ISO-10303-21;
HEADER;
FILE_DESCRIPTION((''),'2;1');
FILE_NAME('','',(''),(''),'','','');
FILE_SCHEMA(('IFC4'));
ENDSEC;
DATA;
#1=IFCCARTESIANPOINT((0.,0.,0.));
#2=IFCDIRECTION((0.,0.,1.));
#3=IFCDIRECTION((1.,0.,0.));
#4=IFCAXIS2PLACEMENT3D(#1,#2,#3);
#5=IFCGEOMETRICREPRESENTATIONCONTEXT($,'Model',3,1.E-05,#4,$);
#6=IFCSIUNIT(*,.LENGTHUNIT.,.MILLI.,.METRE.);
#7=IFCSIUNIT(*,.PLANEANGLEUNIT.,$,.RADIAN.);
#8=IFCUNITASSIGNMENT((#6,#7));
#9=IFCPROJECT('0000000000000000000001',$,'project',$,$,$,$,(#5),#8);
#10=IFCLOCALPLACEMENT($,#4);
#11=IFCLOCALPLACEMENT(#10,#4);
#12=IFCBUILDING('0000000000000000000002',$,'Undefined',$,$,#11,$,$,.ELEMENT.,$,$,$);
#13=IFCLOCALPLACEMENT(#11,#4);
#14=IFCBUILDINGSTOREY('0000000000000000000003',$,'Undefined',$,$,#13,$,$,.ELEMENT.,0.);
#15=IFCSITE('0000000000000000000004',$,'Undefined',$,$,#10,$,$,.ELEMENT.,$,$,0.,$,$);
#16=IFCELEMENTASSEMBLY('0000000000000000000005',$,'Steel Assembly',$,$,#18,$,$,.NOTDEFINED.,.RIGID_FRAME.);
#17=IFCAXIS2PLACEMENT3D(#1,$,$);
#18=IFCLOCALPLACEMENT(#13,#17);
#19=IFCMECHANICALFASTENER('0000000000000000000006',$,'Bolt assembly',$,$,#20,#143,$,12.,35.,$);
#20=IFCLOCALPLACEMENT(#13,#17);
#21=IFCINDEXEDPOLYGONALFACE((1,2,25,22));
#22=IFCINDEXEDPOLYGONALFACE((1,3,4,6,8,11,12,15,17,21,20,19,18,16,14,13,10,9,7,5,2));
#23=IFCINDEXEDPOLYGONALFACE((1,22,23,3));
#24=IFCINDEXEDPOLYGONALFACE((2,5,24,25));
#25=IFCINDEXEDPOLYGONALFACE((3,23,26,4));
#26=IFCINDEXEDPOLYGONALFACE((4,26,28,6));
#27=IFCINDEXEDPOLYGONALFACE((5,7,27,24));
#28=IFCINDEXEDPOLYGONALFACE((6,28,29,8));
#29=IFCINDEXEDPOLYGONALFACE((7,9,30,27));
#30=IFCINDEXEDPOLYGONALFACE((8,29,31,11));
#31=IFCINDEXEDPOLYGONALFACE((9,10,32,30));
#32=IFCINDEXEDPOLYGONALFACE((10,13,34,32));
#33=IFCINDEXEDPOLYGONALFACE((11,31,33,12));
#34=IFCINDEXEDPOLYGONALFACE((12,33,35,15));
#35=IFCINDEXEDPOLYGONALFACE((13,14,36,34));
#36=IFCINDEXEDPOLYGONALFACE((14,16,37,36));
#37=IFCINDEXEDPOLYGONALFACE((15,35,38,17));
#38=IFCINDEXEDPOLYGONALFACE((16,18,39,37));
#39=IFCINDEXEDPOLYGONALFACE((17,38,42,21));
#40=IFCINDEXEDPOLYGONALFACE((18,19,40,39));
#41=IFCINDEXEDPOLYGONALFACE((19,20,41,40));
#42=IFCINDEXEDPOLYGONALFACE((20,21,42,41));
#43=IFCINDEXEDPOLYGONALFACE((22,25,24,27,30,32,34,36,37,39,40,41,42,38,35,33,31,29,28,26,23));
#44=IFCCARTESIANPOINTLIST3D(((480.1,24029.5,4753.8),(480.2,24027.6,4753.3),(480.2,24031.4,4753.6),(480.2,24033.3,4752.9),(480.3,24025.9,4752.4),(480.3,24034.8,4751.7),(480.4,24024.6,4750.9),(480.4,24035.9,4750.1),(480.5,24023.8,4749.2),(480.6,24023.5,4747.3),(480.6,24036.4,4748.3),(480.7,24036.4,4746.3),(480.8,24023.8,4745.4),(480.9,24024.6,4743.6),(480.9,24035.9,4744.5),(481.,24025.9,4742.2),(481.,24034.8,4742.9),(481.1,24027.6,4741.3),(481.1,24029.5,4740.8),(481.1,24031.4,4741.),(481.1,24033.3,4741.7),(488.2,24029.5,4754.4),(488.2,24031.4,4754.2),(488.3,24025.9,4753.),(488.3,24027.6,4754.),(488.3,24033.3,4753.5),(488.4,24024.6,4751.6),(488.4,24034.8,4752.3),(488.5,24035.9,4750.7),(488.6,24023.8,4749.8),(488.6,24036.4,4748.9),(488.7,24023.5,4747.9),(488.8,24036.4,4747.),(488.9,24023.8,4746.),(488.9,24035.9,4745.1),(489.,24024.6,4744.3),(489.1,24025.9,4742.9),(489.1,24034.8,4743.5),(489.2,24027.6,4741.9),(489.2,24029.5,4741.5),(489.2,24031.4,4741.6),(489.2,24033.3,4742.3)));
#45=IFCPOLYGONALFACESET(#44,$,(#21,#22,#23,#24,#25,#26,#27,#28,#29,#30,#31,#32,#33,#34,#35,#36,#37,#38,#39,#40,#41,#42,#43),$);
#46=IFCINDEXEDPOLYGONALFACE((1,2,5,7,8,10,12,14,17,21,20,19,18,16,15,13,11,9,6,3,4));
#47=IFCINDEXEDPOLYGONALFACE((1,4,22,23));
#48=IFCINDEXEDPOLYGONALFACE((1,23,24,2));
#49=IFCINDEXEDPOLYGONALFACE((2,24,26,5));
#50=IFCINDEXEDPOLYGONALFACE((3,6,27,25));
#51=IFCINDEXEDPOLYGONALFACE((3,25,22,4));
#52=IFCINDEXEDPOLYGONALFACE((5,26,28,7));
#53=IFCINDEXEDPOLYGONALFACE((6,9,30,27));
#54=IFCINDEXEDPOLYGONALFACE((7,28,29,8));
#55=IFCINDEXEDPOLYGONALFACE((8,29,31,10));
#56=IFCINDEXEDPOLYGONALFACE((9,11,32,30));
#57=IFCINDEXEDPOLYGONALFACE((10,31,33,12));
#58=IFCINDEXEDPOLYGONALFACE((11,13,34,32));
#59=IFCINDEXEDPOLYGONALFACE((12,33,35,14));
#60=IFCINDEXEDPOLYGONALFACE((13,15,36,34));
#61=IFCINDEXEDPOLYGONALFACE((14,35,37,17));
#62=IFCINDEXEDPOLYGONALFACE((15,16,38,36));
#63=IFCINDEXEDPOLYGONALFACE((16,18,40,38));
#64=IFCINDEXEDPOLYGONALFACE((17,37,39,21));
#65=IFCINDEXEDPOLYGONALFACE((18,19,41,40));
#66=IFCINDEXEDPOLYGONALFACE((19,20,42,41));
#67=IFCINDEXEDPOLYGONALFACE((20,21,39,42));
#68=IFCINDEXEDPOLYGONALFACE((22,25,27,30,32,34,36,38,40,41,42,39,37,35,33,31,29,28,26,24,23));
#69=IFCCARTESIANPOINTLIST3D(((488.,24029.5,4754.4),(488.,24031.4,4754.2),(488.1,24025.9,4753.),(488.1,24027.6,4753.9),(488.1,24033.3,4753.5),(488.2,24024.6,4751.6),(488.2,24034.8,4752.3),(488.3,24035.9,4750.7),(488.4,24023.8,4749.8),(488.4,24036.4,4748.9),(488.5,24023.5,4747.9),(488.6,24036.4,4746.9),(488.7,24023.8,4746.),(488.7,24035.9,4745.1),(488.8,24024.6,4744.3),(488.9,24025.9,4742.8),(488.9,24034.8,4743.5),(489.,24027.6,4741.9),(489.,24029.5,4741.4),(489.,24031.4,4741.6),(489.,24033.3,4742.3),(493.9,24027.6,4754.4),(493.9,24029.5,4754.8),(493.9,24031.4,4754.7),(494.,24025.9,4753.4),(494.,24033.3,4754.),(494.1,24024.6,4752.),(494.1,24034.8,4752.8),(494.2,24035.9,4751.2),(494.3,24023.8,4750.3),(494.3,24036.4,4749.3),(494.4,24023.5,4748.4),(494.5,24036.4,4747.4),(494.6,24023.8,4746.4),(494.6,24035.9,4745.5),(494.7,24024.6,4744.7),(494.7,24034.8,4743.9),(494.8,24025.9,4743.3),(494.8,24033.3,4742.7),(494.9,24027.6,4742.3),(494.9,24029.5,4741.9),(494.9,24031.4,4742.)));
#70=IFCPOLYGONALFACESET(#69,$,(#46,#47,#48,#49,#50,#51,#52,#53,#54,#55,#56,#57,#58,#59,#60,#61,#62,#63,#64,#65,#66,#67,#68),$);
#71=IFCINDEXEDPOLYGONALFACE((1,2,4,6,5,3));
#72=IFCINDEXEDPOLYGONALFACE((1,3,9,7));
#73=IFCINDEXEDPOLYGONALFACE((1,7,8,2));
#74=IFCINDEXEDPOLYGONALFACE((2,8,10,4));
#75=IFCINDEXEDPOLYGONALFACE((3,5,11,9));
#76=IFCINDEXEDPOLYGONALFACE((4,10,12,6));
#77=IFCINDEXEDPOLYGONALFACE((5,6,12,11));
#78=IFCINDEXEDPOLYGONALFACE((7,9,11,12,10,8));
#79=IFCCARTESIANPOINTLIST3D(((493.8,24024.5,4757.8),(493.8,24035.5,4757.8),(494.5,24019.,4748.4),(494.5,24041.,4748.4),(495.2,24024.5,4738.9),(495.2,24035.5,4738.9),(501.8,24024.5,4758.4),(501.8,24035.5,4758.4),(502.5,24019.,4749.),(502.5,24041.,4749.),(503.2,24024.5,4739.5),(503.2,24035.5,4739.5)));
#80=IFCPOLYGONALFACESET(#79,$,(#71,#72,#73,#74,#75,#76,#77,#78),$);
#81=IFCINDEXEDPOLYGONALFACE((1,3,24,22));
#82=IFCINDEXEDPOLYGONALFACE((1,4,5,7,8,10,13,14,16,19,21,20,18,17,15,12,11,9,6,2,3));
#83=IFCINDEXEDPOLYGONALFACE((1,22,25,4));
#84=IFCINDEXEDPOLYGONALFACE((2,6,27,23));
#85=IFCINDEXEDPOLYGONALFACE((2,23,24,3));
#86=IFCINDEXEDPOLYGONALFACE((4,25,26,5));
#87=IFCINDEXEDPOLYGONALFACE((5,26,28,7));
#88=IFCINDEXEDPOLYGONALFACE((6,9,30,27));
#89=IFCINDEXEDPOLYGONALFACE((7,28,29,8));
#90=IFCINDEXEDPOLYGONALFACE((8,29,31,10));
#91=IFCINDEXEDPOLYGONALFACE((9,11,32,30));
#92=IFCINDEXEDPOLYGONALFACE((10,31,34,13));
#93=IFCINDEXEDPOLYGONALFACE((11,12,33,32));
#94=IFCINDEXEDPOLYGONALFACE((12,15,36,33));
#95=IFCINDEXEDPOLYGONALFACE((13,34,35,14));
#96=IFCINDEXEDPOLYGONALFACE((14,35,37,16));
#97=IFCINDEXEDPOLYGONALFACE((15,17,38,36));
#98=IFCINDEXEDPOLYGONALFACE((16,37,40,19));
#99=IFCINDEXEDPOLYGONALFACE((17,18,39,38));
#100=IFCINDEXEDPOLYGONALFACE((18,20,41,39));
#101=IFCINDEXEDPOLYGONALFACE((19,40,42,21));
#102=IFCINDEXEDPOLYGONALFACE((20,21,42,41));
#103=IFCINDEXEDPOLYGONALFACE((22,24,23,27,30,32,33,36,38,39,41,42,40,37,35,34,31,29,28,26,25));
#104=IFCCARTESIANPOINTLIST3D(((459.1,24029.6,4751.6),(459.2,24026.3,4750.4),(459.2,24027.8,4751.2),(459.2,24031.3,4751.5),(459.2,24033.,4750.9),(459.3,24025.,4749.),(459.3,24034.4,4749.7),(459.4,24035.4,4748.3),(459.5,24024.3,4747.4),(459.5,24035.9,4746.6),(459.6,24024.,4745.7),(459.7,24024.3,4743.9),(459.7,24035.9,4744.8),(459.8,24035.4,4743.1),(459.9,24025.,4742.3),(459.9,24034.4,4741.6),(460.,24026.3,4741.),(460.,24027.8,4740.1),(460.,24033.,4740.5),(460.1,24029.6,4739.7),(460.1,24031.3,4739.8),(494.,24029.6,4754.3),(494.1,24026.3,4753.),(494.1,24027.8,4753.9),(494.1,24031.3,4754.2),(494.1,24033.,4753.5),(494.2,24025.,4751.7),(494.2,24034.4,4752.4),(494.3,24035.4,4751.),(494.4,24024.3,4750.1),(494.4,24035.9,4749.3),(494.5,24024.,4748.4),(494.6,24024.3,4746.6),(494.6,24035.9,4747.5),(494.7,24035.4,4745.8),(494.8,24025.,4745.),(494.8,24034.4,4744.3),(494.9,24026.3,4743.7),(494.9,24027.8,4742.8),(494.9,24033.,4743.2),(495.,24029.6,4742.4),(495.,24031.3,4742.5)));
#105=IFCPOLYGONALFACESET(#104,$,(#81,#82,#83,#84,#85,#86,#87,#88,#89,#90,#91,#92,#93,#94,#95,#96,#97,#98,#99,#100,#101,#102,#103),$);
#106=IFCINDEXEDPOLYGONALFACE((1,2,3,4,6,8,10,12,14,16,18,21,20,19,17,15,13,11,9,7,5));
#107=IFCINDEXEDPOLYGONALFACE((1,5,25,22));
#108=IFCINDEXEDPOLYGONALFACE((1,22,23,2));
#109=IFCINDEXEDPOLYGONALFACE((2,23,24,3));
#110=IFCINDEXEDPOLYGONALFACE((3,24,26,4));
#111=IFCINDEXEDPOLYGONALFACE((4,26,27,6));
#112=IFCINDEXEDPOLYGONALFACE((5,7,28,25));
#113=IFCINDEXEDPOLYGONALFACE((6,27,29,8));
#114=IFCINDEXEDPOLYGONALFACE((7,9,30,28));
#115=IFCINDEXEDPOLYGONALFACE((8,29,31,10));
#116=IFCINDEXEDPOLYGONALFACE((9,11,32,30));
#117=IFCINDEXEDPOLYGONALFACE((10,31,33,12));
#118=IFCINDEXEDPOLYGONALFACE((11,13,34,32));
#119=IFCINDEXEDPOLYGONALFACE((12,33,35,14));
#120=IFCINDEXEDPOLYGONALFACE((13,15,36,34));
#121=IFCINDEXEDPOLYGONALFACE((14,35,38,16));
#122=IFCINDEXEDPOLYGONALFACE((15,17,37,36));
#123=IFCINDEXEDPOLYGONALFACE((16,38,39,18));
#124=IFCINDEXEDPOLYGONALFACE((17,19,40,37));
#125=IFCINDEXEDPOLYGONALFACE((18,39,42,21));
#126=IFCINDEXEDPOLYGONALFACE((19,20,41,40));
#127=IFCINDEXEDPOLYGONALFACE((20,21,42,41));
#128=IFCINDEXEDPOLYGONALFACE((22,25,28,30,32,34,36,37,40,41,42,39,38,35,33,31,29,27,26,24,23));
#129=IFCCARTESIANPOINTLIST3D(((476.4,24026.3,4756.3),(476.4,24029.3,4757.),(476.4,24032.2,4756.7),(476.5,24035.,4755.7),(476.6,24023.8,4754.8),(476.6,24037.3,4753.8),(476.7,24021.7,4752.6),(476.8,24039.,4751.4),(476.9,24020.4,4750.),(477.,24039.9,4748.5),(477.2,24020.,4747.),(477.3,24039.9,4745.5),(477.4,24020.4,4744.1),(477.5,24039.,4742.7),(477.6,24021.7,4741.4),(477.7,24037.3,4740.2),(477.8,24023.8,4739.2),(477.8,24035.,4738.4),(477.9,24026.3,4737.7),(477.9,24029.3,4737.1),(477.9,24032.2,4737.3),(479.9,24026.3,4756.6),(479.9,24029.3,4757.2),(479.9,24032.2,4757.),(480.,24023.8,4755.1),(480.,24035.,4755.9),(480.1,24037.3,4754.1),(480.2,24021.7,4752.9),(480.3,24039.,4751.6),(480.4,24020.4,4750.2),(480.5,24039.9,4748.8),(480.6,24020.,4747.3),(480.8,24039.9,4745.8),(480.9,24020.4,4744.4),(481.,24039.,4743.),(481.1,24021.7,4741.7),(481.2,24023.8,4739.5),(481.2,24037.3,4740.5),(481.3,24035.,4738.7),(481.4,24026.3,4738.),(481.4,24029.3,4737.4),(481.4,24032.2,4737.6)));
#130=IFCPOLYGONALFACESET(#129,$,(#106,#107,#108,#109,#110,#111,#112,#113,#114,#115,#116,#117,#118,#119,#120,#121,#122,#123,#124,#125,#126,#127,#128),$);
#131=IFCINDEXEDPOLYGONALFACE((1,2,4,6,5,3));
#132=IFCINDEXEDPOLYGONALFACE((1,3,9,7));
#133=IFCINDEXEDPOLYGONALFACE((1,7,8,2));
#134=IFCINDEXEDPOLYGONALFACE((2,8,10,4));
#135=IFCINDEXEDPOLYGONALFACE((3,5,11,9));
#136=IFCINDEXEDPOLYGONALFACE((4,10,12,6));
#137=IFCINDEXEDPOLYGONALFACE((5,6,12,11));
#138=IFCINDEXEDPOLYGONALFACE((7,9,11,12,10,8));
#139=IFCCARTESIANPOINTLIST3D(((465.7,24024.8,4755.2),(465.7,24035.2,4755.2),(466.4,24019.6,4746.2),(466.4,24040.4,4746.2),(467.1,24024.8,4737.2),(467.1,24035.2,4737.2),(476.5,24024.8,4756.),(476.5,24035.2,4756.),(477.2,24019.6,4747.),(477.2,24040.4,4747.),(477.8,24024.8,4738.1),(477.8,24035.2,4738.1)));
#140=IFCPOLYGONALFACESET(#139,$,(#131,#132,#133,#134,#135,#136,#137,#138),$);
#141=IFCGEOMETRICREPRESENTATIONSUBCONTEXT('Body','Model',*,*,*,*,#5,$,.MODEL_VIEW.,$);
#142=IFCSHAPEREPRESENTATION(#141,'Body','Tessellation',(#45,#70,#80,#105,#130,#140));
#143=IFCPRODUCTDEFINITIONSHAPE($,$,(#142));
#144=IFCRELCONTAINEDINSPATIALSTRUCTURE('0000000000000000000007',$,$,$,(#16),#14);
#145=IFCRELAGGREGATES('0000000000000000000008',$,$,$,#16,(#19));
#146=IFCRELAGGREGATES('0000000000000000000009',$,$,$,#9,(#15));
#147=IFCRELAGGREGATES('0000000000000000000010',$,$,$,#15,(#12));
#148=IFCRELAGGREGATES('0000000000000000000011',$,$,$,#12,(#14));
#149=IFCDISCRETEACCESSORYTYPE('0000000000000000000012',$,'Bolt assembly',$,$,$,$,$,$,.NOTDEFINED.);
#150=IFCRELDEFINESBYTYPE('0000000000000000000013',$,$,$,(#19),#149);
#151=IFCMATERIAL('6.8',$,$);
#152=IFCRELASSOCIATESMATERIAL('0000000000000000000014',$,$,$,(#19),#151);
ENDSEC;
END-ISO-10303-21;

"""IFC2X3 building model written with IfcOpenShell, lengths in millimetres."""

from ifc_helpers import new_model, si_unit, frame, origin_with_axes, origin_2d_with_axis, place, context, subcontext, project, spatial, polyline, circle, outline, extrude, source, transform, mapped, material, type_object, element, aggregate, save


model = new_model("IFC2X3")

# Units and contexts
model_context = context("Model", 3, precision=1e-05, world=origin_with_axes())
body_context = subcontext(model_context, "Body", "Model", "MODEL_VIEW")
ifc_project = project(units=[si_unit("LENGTHUNIT", "METRE", prefix="MILLI"), si_unit("PLANEANGLEUNIT", "RADIAN")], contexts=[model_context])

# Site, building, storey
site_placement = place(None, origin_with_axes())
site = spatial("IfcSite", under=ifc_project, at=site_placement, Name="Undefined", CompositionType="ELEMENT", RefElevation=0.0)
building_placement = place(site_placement, origin_with_axes())
building = spatial("IfcBuilding", under=site, at=building_placement, Name="Undefined", CompositionType="ELEMENT")
storey_placement = place(building_placement, origin_with_axes())
storey = spatial("IfcBuildingStorey", under=building, at=storey_placement, Name="Undefined", CompositionType="ELEMENT", Elevation=0.0)

# Element assembly
assembly_1_placement = place(storey_placement, origin_with_axes())
assembly_1 = element("IfcElementAssembly", 1, at=assembly_1_placement, inside=storey, Name="Steel Assembly", AssemblyPlace="NOTDEFINED", PredefinedType="RIGID_FRAME")

# Mechanical fastener
ifc_material_1 = material(Name="6.8")
discrete_accessory_type_1 = type_object("IfcDiscreteAccessoryType", Name="Bolt assembly")
shared_shape_1 = source(origin_with_axes(), body_context, "Body", "SweptSolid", [
    extrude(circle(Radius=6.5, at=origin_2d_with_axis()), frame((0.0, 2.9, 0.0), z_axis=(0.0, 1.0, 0.0), x_axis=(1.0, 0.0, 0.0)), (0.0, 0.0, 1.0), 8.1),
    extrude(circle(Radius=6.5, at=origin_2d_with_axis()), frame((0.0, -2.9, 0.0), z_axis=(0.0, 1.0, 0.0), x_axis=(1.0, 0.0, 0.0)), (0.0, 0.0, 1.0), 5.9),
    extrude(outline(polyline([(11.0, 0.0), (5.5, 9.5), (-5.5, 9.5), (-11.0, 0.0), (-5.5, -9.5), (5.5, -9.5), (11.0, 0.0)])), frame((0.0, -11.0, 0.0), z_axis=(0.0, 1.0, 0.0), x_axis=(1.0, 0.0, 0.0)), (0.0, 0.0, 1.0), 8.0),
    extrude(circle(Radius=6.0, at=origin_2d_with_axis()), frame((0.0, -3.0, 0.0), z_axis=(0.0, 1.0, 0.0), x_axis=(1.0, 0.0, 0.0)), (0.0, 0.0, 1.0), 35.0),
    extrude(circle(Radius=10.0, at=origin_2d_with_axis()), frame((0.0, 11.0, 0.0), z_axis=(0.0, 1.0, 0.0), x_axis=(1.0, 0.0, 0.0)), (0.0, 0.0, 1.0), 3.5),
    extrude(outline(polyline([(10.4, 0.0), (5.2, 9.0), (-5.2, 9.0), (-10.4, 0.0), (-5.2, -9.0), (5.2, -9.0), (10.4, 0.0)])), frame((0.0, 14.5, 0.0), z_axis=(0.0, 1.0, 0.0), x_axis=(1.0, 0.0, 0.0)), (0.0, 0.0, 1.0), 10.8),
])
mechanical_fastener_1_placement = place(assembly_1_placement, frame((491.6, 24030.0, 4748.1), z_axis=(0.076696, 0.0, -0.997054), x_axis=(0.0, -1.0, 0.0)))
mechanical_fastener_1 = element("IfcMechanicalFastener", 2, at=mechanical_fastener_1_placement, type_object=discrete_accessory_type_1, material=ifc_material_1, Name="Bolt assembly", NominalDiameter=12.0, NominalLength=35.0, context=body_context, shape_type="MappedRepresentation", body=[
    mapped(shared_shape_1, transform((0.0, 0.0, 0.0))),
])
aggregate(assembly_1, [mechanical_fastener_1])

save(model, "model.ifc")
